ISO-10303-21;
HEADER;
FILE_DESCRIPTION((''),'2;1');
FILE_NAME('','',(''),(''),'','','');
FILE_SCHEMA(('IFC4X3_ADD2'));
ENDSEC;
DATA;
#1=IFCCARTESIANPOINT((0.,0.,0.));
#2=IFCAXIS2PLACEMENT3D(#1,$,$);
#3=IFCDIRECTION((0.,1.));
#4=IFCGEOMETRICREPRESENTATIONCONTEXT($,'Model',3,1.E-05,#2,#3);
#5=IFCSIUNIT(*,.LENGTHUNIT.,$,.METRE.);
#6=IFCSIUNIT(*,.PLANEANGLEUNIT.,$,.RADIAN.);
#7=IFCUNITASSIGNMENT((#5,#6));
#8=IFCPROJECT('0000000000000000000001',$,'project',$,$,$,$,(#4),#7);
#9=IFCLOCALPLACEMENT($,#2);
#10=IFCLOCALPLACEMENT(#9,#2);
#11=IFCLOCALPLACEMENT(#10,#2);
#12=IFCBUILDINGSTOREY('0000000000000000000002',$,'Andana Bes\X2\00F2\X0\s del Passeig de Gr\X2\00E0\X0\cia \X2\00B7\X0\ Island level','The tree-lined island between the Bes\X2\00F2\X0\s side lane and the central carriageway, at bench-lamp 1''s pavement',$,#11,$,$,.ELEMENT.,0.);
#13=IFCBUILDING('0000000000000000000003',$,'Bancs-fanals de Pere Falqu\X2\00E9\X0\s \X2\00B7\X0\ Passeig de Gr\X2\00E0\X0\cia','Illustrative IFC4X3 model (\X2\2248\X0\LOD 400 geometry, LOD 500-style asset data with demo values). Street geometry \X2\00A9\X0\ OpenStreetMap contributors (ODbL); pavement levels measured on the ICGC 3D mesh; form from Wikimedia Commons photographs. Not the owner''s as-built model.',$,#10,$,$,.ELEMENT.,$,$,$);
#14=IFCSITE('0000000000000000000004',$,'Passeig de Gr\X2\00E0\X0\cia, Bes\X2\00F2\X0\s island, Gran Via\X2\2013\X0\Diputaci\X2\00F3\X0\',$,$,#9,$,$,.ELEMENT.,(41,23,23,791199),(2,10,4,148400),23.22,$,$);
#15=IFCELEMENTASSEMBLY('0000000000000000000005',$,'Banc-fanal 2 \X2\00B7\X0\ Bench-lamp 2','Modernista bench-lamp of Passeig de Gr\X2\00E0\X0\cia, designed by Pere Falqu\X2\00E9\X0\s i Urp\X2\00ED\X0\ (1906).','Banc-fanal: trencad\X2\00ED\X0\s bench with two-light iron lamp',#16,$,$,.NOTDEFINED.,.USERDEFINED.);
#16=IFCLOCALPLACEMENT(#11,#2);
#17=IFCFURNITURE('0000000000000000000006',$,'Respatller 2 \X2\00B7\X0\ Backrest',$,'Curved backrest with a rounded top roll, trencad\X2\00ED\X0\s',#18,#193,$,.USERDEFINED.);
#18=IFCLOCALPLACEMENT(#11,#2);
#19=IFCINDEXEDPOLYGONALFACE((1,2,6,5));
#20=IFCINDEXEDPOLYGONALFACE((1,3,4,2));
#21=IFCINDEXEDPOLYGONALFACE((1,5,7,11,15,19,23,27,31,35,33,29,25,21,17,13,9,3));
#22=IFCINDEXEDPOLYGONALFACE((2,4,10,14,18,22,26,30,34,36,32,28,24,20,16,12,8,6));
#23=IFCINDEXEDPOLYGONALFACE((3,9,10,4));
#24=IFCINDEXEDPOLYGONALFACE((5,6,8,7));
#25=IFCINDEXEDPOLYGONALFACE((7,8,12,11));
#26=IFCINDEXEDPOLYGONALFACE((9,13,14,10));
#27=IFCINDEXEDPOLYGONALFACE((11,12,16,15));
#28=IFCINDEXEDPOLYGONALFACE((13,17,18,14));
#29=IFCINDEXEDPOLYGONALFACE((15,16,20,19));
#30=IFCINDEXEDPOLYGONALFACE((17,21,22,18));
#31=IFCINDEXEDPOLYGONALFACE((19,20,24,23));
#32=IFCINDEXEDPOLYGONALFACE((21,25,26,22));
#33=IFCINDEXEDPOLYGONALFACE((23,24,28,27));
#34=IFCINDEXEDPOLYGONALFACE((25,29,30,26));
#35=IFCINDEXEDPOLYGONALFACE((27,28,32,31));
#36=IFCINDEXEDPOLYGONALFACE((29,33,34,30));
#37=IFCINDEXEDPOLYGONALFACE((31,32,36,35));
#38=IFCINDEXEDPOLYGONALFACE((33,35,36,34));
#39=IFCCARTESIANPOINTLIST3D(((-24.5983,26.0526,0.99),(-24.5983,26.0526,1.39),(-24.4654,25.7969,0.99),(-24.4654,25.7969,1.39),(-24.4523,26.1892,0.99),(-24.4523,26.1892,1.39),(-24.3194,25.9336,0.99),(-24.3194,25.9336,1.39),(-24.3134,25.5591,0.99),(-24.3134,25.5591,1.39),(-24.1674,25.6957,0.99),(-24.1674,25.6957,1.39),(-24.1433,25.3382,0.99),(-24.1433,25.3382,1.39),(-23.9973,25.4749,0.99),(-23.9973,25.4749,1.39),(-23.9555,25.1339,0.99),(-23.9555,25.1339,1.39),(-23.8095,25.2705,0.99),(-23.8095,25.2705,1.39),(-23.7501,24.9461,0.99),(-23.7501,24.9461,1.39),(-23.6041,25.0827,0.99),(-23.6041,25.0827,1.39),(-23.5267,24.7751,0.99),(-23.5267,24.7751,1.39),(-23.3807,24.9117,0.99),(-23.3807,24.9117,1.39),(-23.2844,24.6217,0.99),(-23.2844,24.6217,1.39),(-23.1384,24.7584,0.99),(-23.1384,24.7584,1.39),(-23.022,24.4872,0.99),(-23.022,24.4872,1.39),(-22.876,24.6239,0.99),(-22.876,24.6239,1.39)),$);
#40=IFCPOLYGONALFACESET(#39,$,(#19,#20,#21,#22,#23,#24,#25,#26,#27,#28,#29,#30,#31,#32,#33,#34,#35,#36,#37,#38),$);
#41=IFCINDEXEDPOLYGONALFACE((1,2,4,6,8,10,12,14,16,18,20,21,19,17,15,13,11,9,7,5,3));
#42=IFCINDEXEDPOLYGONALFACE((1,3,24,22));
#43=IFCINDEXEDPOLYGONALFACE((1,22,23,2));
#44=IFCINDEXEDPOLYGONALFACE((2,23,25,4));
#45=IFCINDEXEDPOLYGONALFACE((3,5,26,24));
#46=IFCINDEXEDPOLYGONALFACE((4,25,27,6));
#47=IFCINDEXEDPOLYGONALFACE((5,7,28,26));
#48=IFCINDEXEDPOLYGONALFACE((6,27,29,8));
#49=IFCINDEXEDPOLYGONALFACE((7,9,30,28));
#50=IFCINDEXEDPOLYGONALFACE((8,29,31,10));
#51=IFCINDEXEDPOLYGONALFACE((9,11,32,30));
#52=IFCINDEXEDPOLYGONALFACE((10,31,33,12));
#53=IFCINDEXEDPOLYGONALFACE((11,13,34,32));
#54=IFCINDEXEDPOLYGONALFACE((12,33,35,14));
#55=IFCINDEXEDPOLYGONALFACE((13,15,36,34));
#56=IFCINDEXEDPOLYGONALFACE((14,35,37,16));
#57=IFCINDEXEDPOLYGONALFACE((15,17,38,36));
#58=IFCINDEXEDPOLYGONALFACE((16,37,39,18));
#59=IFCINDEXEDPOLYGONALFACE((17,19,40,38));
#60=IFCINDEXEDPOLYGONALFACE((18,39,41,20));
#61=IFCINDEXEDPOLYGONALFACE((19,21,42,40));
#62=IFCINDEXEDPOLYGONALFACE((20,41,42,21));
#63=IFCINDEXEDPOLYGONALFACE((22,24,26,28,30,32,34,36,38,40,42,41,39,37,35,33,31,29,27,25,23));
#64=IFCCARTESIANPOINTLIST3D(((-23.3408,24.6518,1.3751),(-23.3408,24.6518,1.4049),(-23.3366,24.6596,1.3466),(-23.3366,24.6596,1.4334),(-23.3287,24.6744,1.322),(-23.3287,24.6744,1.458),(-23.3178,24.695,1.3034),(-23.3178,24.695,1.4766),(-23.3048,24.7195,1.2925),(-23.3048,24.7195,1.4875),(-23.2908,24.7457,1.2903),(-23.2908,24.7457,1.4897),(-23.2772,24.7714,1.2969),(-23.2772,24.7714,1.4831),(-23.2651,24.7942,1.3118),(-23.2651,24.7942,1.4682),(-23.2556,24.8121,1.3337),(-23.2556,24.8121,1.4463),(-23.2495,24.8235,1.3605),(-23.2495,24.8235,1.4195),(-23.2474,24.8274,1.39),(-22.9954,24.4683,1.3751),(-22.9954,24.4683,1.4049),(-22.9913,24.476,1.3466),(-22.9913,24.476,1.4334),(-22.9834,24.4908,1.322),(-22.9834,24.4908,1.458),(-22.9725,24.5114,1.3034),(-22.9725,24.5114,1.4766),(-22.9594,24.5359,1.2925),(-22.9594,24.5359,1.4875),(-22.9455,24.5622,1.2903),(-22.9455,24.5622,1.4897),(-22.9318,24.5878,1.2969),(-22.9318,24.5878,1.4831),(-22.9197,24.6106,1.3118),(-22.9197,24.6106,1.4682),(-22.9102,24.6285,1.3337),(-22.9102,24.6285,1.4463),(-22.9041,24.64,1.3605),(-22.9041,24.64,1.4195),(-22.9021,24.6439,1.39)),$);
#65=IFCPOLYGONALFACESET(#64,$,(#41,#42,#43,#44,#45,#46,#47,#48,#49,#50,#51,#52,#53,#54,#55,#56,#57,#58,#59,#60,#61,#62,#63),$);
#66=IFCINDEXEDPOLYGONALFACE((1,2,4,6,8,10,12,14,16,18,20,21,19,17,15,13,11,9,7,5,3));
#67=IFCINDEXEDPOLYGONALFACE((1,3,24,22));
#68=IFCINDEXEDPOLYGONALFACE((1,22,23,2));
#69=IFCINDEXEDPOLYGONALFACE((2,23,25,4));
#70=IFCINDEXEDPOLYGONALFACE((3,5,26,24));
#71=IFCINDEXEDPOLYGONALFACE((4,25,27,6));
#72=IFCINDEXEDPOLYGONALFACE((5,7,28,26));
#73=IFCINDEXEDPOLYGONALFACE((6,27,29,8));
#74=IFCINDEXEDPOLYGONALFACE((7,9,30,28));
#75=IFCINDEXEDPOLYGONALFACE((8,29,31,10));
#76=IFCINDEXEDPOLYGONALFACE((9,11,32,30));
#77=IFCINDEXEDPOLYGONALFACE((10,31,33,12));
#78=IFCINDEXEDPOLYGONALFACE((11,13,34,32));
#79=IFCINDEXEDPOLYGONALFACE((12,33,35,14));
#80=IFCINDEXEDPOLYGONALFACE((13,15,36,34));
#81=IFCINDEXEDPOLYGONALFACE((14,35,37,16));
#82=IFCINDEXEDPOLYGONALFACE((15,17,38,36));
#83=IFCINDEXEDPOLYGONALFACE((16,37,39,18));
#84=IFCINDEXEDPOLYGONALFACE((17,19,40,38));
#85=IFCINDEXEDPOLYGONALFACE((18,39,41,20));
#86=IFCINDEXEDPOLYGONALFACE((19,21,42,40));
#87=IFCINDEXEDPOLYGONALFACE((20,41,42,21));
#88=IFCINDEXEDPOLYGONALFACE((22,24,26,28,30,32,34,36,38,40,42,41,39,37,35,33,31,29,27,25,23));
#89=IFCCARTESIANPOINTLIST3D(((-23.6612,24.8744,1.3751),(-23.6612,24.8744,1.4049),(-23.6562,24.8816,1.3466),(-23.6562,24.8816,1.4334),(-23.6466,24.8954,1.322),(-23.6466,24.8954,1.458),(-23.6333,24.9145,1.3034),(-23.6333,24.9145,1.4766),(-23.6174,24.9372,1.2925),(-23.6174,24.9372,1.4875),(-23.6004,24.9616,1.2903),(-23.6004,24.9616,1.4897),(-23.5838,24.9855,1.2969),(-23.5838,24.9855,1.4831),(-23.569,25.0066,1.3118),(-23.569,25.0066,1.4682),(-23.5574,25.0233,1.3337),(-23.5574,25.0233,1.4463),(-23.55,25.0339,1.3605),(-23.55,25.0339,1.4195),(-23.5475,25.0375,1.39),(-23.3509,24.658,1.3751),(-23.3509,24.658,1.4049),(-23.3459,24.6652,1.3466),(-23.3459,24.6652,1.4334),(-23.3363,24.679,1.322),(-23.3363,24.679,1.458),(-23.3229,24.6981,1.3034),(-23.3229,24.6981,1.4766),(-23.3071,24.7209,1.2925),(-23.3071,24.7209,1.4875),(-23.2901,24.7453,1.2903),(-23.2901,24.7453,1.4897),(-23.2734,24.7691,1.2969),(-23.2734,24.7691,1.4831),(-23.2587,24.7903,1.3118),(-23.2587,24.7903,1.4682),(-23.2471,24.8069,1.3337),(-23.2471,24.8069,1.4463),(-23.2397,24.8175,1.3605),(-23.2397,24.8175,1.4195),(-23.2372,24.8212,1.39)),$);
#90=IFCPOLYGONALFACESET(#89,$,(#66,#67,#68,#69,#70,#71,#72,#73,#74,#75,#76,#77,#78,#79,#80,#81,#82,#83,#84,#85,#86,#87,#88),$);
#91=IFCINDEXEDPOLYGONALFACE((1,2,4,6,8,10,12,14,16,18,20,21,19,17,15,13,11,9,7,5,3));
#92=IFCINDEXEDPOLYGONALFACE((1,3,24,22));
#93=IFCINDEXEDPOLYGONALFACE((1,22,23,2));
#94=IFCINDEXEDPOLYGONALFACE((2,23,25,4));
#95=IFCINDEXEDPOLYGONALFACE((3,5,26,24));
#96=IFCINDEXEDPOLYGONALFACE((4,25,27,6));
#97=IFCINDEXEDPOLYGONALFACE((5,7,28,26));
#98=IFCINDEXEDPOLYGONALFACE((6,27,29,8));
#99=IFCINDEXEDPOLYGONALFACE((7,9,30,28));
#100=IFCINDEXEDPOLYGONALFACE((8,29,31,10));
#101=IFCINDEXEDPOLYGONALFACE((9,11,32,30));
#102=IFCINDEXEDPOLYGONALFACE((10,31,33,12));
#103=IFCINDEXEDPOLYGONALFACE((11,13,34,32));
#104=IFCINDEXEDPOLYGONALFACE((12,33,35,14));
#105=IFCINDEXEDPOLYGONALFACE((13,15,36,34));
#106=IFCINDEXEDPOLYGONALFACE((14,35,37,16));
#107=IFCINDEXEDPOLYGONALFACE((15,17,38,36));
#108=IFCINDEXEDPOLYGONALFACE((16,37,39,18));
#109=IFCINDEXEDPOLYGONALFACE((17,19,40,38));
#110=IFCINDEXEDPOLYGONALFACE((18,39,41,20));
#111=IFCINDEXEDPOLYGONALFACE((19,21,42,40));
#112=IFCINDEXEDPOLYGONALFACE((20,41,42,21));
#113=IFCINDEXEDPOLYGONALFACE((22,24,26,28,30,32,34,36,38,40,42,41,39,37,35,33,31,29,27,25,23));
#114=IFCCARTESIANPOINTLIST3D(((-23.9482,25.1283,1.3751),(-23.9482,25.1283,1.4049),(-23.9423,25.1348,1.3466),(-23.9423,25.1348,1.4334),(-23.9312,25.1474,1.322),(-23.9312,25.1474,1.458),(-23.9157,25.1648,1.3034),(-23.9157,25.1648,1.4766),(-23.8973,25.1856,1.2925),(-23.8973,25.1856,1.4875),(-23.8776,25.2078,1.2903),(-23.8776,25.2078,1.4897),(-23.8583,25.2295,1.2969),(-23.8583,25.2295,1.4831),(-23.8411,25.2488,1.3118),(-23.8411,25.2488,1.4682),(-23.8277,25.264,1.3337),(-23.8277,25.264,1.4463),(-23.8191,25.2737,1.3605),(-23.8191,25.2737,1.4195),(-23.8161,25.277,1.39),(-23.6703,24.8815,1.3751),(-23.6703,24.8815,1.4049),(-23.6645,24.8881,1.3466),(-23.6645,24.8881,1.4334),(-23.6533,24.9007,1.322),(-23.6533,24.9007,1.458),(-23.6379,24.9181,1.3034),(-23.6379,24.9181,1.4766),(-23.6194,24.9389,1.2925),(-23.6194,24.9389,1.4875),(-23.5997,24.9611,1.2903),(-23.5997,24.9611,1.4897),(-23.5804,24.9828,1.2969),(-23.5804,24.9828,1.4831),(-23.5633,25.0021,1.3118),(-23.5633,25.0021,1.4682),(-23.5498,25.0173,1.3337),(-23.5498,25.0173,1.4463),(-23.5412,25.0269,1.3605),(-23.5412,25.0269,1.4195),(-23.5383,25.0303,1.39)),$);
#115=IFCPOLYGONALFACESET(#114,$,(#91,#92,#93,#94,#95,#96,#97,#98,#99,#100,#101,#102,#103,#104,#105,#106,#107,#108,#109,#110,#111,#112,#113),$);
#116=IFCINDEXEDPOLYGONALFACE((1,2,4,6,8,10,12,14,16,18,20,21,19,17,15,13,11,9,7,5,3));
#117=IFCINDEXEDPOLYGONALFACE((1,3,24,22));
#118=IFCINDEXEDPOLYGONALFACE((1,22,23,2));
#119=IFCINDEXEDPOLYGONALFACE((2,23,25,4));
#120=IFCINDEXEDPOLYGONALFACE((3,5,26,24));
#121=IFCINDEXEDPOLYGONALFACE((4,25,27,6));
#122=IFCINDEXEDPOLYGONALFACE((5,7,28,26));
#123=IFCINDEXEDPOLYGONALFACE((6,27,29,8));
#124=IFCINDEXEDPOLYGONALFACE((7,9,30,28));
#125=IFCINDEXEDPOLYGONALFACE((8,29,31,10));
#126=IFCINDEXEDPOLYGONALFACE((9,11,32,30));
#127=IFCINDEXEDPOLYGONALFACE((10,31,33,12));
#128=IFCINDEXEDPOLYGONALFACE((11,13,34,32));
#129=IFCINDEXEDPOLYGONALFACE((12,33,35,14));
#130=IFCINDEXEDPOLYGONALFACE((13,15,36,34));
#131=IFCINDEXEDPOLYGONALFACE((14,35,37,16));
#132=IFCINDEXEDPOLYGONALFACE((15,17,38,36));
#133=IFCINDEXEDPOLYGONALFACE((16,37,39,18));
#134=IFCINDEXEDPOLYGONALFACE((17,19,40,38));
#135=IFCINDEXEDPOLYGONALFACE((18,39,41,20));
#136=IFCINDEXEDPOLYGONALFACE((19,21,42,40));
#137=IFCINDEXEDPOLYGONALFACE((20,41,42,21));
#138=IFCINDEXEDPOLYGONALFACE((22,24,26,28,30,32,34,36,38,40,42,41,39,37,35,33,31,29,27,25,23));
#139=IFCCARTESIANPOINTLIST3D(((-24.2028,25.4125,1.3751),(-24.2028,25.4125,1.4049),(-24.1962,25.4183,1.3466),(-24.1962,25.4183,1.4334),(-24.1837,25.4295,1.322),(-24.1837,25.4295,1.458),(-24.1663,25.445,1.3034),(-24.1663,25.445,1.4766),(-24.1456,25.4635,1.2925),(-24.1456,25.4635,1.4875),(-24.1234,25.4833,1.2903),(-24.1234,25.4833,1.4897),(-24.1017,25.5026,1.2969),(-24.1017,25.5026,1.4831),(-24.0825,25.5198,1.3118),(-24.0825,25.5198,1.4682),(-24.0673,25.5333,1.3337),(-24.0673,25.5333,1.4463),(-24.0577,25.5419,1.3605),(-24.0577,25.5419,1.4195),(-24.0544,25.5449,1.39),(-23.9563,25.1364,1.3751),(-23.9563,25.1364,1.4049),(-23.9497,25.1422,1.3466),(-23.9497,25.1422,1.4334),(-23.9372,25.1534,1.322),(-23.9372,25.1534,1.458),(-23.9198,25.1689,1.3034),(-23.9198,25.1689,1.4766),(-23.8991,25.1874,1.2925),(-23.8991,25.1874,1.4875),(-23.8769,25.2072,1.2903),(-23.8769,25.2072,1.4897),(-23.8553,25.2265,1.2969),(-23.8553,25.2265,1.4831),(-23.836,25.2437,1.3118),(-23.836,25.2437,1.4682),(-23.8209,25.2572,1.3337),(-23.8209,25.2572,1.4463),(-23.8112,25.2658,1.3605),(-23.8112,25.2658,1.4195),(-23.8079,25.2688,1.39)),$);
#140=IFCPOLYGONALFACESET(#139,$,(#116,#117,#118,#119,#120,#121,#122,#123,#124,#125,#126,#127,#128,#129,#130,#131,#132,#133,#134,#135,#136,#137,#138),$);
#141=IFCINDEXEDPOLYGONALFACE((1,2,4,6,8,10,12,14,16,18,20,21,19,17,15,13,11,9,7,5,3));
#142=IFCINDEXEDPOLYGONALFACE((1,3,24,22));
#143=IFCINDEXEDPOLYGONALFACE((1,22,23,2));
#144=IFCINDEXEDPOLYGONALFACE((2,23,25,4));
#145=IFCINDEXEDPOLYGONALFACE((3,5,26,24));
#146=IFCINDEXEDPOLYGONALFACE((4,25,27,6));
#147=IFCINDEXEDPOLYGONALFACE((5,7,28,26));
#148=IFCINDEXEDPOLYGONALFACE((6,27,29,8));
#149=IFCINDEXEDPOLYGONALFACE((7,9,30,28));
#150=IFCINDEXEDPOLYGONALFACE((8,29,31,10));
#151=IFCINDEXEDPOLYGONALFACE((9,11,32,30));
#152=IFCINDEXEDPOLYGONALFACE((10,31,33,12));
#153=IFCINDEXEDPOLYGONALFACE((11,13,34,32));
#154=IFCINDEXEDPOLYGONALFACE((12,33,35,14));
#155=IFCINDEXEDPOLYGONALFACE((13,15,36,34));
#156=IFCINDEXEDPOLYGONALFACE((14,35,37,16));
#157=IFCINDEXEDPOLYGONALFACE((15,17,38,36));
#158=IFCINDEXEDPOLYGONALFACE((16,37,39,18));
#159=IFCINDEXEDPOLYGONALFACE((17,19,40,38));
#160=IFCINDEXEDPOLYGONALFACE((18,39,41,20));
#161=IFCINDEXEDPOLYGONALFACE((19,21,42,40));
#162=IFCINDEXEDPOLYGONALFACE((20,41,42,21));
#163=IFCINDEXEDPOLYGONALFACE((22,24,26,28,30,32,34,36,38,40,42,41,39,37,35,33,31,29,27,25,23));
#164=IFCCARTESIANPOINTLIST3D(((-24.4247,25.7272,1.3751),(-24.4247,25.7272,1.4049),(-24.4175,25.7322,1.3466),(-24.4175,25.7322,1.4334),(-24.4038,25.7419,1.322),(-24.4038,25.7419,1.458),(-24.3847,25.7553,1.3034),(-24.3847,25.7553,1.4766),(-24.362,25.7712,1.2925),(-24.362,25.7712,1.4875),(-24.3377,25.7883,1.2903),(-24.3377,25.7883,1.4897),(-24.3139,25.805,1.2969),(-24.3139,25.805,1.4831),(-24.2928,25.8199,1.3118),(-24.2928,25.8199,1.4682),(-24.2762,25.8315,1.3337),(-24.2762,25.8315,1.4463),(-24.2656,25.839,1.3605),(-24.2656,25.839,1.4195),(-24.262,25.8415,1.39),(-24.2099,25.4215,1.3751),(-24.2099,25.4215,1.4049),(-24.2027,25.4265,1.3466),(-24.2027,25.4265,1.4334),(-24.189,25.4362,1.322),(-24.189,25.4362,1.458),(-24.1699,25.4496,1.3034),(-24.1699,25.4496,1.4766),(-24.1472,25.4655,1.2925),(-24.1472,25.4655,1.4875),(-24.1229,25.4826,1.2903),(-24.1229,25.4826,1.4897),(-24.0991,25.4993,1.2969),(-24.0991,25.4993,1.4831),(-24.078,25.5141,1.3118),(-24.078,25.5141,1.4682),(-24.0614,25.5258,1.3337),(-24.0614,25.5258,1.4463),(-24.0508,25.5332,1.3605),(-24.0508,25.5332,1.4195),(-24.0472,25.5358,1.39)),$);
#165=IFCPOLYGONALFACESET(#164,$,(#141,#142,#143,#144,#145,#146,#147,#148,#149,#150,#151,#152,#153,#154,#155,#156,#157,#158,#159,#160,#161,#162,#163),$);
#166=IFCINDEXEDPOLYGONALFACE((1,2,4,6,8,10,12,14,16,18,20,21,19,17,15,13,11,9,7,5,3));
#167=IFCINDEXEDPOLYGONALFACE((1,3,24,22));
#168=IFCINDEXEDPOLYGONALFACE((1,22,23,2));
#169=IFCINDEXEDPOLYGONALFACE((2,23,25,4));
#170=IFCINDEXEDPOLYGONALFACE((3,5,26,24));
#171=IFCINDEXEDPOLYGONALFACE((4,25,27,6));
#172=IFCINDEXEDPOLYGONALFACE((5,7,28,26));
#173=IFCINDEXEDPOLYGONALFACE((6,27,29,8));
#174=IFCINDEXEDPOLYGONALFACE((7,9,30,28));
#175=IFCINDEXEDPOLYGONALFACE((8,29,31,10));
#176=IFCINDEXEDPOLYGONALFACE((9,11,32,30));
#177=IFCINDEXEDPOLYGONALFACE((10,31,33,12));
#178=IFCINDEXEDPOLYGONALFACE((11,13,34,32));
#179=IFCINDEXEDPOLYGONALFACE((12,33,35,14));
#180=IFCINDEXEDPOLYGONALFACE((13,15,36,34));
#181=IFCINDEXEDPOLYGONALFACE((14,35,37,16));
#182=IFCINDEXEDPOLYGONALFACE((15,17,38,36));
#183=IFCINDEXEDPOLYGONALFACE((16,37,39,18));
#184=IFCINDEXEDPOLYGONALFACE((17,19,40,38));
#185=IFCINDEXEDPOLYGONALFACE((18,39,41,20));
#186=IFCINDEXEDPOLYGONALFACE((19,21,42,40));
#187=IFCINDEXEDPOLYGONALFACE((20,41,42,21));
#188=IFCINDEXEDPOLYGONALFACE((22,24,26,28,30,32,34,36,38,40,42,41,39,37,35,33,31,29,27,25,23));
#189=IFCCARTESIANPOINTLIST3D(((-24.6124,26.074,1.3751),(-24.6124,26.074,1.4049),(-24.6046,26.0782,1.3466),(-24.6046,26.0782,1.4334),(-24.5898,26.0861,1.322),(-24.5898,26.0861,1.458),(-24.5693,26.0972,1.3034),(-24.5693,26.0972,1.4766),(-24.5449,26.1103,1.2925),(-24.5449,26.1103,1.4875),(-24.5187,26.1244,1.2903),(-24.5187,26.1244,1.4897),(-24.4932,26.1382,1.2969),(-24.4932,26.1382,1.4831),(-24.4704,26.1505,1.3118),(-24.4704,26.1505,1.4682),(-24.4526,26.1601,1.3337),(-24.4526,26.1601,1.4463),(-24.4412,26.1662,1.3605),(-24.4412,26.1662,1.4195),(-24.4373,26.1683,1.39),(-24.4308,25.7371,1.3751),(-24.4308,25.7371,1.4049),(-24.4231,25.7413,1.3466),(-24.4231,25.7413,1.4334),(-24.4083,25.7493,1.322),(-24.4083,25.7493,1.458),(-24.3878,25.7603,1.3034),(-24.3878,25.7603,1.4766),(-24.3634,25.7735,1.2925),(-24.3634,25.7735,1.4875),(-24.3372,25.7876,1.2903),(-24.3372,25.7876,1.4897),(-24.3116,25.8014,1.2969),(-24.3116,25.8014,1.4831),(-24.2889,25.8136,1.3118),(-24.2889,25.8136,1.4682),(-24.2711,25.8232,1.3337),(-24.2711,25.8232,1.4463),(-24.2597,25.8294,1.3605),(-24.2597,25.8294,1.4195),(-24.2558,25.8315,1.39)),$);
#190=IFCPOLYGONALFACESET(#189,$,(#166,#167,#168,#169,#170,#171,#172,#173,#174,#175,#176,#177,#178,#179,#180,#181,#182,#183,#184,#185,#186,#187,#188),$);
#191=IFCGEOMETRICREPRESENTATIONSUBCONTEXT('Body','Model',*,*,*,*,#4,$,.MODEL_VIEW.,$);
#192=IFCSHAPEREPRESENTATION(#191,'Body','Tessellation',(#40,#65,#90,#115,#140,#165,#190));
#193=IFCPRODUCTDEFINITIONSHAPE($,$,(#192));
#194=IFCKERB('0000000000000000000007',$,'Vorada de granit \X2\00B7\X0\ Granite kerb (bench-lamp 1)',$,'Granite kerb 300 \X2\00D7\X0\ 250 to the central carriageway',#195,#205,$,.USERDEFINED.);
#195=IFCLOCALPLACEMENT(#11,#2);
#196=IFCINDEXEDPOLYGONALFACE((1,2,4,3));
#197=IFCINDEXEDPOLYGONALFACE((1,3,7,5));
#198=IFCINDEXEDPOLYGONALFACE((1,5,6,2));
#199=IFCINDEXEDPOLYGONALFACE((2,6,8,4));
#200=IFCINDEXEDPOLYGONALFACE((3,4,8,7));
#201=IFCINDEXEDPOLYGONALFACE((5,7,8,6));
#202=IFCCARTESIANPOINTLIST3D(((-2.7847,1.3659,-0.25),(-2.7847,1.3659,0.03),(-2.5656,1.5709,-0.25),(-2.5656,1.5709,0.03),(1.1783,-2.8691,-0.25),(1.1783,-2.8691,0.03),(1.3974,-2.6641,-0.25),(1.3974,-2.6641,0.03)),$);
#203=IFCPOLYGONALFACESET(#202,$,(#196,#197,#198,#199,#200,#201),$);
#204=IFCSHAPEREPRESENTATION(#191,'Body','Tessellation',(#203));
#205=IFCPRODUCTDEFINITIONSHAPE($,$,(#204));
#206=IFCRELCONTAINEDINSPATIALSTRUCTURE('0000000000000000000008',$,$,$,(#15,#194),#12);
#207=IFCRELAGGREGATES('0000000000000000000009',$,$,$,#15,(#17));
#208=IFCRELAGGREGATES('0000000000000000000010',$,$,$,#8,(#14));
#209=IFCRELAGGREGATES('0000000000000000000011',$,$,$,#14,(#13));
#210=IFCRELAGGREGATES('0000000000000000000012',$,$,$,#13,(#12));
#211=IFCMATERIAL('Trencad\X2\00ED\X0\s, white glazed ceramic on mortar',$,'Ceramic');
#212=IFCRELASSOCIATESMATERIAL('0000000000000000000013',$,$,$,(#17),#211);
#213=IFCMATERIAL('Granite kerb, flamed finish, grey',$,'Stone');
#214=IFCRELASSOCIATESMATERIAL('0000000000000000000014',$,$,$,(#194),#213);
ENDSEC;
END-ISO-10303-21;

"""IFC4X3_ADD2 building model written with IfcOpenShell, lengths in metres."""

from ifc_helpers import new_model, si_unit, direction, frame, frame_2d, origin, origin_2d_with_axis, place, context, subcontext, project, spatial, polyline, rectangle, circle, outline, extrude, material, element, aggregate, save


model = new_model("IFC4X3_ADD2")

# Units and contexts
model_context = context("Model", 3, precision=1e-05, world=origin(), true_north=direction((0.0, 1.0)))
body_context = subcontext(model_context, "Body", "Model", "MODEL_VIEW")
ifc_project = project(units=[si_unit("LENGTHUNIT", "METRE"), si_unit("PLANEANGLEUNIT", "RADIAN")], contexts=[model_context])

# Site, building, storey
site_placement = place(None, origin())
site = spatial("IfcSite", under=ifc_project, at=site_placement, Name="Passeig de Gràcia, Besòs island, Gran Via–Diputació", CompositionType="ELEMENT", RefLatitude=(41, 23, 23, 791199), RefLongitude=(2, 10, 4, 148400), RefElevation=23.22)
building_placement = place(site_placement, origin())
building = spatial("IfcBuilding", under=site, at=building_placement, Name="Bancs-fanals de Pere Falqués · Passeig de Gràcia", Description="Illustrative IFC4X3 model (≈LOD 400 geometry, LOD 500-style asset data with demo values). Street geometry © OpenStreetMap contributors (ODbL); pavement levels measured on the ICGC 3D mesh; form from Wikimedia Commons photographs. Not the owner's as-built model.", CompositionType="ELEMENT")
storey_placement = place(building_placement, origin())
storey = spatial("IfcBuildingStorey", under=building, at=storey_placement, Name="Andana Besòs del Passeig de Gràcia · Island level", Description="The tree-lined island between the Besòs side lane and the central carriageway, at bench-lamp 1's pavement", CompositionType="ELEMENT", Elevation=0.0)

# Element assembly
assembly_1_placement = place(building_placement, origin())
assembly_1 = element("IfcElementAssembly", 1, at=assembly_1_placement, inside=storey, Name="Banc-fanal 2 · Bench-lamp 2", Description="Modernista bench-lamp of Passeig de Gràcia, designed by Pere Falqués i Urpí (1906).", ObjectType="Banc-fanal: trencadís bench with two-light iron lamp", AssemblyPlace="NOTDEFINED", PredefinedType="USERDEFINED")

# Shared definitions
ifc_material_1 = material(Name="Trencadís, white glazed ceramic on mortar", Category="Ceramic")

# Furniture
furniture_1_placement = place(building_placement, origin())
furniture_1 = element("IfcFurniture", 2, at=furniture_1_placement, material=ifc_material_1, Name="Respatller 2 · Backrest", ObjectType="Curved backrest with a rounded top roll, trencadís", PredefinedType="USERDEFINED", context=body_context, shape_type="SweptSolid", body=[
    extrude(outline(polyline([(-22.876, 24.6239), (-23.1384, 24.7584), (-23.3807, 24.9117), (-23.6041, 25.0827), (-23.8095, 25.2705), (-23.9973, 25.4749), (-24.1674, 25.6957), (-24.3194, 25.9336), (-24.4523, 26.1892), (-24.5983, 26.0526), (-24.4654, 25.7969), (-24.3134, 25.5591), (-24.1433, 25.3382), (-23.9555, 25.1339), (-23.7501, 24.9461), (-23.5267, 24.7751), (-23.2844, 24.6217), (-23.022, 24.4872), (-22.876, 24.6239)])), frame((0.0, 0.0, 0.99)), (0.0, 0.0, 1.0), 0.4),
    extrude(circle(Radius=0.1, at=origin_2d_with_axis()), frame((-22.949, 24.5556, 1.39), z_axis=(-0.88301, 0.469354, 0.0), x_axis=(0.469354, 0.88301, 0.0)), (0.0, 0.0, 1.0), 0.3911),
    extrude(circle(Radius=0.1, at=origin_2d_with_axis()), frame((-23.2943, 24.7391, 1.39), z_axis=(-0.820307, 0.571924, 0.0), x_axis=(0.571924, 0.820307, 0.0)), (0.0, 0.0, 1.0), 0.3783),
    extrude(circle(Radius=0.1, at=origin_2d_with_axis()), frame((-23.6047, 24.9555, 1.39), z_axis=(-0.74778, 0.663947, 0.0), x_axis=(0.663947, 0.74778, 0.0)), (0.0, 0.0, 1.0), 0.3716),
    extrude(circle(Radius=0.1, at=origin_2d_with_axis()), frame((-23.8825, 25.2022, 1.39), z_axis=(-0.665944, 0.746002, 0.0), x_axis=(0.746002, 0.665944, 0.0)), (0.0, 0.0, 1.0), 0.3701),
    extrude(circle(Radius=0.1, at=origin_2d_with_axis()), frame((-24.129, 25.4783, 1.39), z_axis=(-0.5749, 0.818223, 0.0), x_axis=(0.818223, 0.5749, 0.0)), (0.0, 0.0, 1.0), 0.3736),
    extrude(circle(Radius=0.1, at=origin_2d_with_axis()), frame((-24.3438, 25.784, 1.39), z_axis=(-0.474363, 0.880329, 0.0), x_axis=(0.880329, 0.474363, 0.0)), (0.0, 0.0, 1.0), 0.3827),
])
aggregate(assembly_1, [furniture_1])

# Kerb
ifc_material_2 = material(Name="Granite kerb, flamed finish, grey", Category="Stone")
kerb_placement = place(building_placement, origin())
element("IfcKerb", 3, at=kerb_placement, inside=storey, material=ifc_material_2, Name="Vorada de granit · Granite kerb (bench-lamp 1)", ObjectType="Granite kerb 300 × 250 to the central carriageway", PredefinedType="USERDEFINED", context=body_context, shape_type="SweptSolid", body=[
    extrude(rectangle(XDim=5.8, YDim=0.3, at=frame_2d((0.0, 0.0), x_axis=(-0.683274, 0.730162))), frame((-0.6937, -0.6491, -0.25)), (0.0, 0.0, 1.0), 0.28),
])

save(model, "model.ifc")
